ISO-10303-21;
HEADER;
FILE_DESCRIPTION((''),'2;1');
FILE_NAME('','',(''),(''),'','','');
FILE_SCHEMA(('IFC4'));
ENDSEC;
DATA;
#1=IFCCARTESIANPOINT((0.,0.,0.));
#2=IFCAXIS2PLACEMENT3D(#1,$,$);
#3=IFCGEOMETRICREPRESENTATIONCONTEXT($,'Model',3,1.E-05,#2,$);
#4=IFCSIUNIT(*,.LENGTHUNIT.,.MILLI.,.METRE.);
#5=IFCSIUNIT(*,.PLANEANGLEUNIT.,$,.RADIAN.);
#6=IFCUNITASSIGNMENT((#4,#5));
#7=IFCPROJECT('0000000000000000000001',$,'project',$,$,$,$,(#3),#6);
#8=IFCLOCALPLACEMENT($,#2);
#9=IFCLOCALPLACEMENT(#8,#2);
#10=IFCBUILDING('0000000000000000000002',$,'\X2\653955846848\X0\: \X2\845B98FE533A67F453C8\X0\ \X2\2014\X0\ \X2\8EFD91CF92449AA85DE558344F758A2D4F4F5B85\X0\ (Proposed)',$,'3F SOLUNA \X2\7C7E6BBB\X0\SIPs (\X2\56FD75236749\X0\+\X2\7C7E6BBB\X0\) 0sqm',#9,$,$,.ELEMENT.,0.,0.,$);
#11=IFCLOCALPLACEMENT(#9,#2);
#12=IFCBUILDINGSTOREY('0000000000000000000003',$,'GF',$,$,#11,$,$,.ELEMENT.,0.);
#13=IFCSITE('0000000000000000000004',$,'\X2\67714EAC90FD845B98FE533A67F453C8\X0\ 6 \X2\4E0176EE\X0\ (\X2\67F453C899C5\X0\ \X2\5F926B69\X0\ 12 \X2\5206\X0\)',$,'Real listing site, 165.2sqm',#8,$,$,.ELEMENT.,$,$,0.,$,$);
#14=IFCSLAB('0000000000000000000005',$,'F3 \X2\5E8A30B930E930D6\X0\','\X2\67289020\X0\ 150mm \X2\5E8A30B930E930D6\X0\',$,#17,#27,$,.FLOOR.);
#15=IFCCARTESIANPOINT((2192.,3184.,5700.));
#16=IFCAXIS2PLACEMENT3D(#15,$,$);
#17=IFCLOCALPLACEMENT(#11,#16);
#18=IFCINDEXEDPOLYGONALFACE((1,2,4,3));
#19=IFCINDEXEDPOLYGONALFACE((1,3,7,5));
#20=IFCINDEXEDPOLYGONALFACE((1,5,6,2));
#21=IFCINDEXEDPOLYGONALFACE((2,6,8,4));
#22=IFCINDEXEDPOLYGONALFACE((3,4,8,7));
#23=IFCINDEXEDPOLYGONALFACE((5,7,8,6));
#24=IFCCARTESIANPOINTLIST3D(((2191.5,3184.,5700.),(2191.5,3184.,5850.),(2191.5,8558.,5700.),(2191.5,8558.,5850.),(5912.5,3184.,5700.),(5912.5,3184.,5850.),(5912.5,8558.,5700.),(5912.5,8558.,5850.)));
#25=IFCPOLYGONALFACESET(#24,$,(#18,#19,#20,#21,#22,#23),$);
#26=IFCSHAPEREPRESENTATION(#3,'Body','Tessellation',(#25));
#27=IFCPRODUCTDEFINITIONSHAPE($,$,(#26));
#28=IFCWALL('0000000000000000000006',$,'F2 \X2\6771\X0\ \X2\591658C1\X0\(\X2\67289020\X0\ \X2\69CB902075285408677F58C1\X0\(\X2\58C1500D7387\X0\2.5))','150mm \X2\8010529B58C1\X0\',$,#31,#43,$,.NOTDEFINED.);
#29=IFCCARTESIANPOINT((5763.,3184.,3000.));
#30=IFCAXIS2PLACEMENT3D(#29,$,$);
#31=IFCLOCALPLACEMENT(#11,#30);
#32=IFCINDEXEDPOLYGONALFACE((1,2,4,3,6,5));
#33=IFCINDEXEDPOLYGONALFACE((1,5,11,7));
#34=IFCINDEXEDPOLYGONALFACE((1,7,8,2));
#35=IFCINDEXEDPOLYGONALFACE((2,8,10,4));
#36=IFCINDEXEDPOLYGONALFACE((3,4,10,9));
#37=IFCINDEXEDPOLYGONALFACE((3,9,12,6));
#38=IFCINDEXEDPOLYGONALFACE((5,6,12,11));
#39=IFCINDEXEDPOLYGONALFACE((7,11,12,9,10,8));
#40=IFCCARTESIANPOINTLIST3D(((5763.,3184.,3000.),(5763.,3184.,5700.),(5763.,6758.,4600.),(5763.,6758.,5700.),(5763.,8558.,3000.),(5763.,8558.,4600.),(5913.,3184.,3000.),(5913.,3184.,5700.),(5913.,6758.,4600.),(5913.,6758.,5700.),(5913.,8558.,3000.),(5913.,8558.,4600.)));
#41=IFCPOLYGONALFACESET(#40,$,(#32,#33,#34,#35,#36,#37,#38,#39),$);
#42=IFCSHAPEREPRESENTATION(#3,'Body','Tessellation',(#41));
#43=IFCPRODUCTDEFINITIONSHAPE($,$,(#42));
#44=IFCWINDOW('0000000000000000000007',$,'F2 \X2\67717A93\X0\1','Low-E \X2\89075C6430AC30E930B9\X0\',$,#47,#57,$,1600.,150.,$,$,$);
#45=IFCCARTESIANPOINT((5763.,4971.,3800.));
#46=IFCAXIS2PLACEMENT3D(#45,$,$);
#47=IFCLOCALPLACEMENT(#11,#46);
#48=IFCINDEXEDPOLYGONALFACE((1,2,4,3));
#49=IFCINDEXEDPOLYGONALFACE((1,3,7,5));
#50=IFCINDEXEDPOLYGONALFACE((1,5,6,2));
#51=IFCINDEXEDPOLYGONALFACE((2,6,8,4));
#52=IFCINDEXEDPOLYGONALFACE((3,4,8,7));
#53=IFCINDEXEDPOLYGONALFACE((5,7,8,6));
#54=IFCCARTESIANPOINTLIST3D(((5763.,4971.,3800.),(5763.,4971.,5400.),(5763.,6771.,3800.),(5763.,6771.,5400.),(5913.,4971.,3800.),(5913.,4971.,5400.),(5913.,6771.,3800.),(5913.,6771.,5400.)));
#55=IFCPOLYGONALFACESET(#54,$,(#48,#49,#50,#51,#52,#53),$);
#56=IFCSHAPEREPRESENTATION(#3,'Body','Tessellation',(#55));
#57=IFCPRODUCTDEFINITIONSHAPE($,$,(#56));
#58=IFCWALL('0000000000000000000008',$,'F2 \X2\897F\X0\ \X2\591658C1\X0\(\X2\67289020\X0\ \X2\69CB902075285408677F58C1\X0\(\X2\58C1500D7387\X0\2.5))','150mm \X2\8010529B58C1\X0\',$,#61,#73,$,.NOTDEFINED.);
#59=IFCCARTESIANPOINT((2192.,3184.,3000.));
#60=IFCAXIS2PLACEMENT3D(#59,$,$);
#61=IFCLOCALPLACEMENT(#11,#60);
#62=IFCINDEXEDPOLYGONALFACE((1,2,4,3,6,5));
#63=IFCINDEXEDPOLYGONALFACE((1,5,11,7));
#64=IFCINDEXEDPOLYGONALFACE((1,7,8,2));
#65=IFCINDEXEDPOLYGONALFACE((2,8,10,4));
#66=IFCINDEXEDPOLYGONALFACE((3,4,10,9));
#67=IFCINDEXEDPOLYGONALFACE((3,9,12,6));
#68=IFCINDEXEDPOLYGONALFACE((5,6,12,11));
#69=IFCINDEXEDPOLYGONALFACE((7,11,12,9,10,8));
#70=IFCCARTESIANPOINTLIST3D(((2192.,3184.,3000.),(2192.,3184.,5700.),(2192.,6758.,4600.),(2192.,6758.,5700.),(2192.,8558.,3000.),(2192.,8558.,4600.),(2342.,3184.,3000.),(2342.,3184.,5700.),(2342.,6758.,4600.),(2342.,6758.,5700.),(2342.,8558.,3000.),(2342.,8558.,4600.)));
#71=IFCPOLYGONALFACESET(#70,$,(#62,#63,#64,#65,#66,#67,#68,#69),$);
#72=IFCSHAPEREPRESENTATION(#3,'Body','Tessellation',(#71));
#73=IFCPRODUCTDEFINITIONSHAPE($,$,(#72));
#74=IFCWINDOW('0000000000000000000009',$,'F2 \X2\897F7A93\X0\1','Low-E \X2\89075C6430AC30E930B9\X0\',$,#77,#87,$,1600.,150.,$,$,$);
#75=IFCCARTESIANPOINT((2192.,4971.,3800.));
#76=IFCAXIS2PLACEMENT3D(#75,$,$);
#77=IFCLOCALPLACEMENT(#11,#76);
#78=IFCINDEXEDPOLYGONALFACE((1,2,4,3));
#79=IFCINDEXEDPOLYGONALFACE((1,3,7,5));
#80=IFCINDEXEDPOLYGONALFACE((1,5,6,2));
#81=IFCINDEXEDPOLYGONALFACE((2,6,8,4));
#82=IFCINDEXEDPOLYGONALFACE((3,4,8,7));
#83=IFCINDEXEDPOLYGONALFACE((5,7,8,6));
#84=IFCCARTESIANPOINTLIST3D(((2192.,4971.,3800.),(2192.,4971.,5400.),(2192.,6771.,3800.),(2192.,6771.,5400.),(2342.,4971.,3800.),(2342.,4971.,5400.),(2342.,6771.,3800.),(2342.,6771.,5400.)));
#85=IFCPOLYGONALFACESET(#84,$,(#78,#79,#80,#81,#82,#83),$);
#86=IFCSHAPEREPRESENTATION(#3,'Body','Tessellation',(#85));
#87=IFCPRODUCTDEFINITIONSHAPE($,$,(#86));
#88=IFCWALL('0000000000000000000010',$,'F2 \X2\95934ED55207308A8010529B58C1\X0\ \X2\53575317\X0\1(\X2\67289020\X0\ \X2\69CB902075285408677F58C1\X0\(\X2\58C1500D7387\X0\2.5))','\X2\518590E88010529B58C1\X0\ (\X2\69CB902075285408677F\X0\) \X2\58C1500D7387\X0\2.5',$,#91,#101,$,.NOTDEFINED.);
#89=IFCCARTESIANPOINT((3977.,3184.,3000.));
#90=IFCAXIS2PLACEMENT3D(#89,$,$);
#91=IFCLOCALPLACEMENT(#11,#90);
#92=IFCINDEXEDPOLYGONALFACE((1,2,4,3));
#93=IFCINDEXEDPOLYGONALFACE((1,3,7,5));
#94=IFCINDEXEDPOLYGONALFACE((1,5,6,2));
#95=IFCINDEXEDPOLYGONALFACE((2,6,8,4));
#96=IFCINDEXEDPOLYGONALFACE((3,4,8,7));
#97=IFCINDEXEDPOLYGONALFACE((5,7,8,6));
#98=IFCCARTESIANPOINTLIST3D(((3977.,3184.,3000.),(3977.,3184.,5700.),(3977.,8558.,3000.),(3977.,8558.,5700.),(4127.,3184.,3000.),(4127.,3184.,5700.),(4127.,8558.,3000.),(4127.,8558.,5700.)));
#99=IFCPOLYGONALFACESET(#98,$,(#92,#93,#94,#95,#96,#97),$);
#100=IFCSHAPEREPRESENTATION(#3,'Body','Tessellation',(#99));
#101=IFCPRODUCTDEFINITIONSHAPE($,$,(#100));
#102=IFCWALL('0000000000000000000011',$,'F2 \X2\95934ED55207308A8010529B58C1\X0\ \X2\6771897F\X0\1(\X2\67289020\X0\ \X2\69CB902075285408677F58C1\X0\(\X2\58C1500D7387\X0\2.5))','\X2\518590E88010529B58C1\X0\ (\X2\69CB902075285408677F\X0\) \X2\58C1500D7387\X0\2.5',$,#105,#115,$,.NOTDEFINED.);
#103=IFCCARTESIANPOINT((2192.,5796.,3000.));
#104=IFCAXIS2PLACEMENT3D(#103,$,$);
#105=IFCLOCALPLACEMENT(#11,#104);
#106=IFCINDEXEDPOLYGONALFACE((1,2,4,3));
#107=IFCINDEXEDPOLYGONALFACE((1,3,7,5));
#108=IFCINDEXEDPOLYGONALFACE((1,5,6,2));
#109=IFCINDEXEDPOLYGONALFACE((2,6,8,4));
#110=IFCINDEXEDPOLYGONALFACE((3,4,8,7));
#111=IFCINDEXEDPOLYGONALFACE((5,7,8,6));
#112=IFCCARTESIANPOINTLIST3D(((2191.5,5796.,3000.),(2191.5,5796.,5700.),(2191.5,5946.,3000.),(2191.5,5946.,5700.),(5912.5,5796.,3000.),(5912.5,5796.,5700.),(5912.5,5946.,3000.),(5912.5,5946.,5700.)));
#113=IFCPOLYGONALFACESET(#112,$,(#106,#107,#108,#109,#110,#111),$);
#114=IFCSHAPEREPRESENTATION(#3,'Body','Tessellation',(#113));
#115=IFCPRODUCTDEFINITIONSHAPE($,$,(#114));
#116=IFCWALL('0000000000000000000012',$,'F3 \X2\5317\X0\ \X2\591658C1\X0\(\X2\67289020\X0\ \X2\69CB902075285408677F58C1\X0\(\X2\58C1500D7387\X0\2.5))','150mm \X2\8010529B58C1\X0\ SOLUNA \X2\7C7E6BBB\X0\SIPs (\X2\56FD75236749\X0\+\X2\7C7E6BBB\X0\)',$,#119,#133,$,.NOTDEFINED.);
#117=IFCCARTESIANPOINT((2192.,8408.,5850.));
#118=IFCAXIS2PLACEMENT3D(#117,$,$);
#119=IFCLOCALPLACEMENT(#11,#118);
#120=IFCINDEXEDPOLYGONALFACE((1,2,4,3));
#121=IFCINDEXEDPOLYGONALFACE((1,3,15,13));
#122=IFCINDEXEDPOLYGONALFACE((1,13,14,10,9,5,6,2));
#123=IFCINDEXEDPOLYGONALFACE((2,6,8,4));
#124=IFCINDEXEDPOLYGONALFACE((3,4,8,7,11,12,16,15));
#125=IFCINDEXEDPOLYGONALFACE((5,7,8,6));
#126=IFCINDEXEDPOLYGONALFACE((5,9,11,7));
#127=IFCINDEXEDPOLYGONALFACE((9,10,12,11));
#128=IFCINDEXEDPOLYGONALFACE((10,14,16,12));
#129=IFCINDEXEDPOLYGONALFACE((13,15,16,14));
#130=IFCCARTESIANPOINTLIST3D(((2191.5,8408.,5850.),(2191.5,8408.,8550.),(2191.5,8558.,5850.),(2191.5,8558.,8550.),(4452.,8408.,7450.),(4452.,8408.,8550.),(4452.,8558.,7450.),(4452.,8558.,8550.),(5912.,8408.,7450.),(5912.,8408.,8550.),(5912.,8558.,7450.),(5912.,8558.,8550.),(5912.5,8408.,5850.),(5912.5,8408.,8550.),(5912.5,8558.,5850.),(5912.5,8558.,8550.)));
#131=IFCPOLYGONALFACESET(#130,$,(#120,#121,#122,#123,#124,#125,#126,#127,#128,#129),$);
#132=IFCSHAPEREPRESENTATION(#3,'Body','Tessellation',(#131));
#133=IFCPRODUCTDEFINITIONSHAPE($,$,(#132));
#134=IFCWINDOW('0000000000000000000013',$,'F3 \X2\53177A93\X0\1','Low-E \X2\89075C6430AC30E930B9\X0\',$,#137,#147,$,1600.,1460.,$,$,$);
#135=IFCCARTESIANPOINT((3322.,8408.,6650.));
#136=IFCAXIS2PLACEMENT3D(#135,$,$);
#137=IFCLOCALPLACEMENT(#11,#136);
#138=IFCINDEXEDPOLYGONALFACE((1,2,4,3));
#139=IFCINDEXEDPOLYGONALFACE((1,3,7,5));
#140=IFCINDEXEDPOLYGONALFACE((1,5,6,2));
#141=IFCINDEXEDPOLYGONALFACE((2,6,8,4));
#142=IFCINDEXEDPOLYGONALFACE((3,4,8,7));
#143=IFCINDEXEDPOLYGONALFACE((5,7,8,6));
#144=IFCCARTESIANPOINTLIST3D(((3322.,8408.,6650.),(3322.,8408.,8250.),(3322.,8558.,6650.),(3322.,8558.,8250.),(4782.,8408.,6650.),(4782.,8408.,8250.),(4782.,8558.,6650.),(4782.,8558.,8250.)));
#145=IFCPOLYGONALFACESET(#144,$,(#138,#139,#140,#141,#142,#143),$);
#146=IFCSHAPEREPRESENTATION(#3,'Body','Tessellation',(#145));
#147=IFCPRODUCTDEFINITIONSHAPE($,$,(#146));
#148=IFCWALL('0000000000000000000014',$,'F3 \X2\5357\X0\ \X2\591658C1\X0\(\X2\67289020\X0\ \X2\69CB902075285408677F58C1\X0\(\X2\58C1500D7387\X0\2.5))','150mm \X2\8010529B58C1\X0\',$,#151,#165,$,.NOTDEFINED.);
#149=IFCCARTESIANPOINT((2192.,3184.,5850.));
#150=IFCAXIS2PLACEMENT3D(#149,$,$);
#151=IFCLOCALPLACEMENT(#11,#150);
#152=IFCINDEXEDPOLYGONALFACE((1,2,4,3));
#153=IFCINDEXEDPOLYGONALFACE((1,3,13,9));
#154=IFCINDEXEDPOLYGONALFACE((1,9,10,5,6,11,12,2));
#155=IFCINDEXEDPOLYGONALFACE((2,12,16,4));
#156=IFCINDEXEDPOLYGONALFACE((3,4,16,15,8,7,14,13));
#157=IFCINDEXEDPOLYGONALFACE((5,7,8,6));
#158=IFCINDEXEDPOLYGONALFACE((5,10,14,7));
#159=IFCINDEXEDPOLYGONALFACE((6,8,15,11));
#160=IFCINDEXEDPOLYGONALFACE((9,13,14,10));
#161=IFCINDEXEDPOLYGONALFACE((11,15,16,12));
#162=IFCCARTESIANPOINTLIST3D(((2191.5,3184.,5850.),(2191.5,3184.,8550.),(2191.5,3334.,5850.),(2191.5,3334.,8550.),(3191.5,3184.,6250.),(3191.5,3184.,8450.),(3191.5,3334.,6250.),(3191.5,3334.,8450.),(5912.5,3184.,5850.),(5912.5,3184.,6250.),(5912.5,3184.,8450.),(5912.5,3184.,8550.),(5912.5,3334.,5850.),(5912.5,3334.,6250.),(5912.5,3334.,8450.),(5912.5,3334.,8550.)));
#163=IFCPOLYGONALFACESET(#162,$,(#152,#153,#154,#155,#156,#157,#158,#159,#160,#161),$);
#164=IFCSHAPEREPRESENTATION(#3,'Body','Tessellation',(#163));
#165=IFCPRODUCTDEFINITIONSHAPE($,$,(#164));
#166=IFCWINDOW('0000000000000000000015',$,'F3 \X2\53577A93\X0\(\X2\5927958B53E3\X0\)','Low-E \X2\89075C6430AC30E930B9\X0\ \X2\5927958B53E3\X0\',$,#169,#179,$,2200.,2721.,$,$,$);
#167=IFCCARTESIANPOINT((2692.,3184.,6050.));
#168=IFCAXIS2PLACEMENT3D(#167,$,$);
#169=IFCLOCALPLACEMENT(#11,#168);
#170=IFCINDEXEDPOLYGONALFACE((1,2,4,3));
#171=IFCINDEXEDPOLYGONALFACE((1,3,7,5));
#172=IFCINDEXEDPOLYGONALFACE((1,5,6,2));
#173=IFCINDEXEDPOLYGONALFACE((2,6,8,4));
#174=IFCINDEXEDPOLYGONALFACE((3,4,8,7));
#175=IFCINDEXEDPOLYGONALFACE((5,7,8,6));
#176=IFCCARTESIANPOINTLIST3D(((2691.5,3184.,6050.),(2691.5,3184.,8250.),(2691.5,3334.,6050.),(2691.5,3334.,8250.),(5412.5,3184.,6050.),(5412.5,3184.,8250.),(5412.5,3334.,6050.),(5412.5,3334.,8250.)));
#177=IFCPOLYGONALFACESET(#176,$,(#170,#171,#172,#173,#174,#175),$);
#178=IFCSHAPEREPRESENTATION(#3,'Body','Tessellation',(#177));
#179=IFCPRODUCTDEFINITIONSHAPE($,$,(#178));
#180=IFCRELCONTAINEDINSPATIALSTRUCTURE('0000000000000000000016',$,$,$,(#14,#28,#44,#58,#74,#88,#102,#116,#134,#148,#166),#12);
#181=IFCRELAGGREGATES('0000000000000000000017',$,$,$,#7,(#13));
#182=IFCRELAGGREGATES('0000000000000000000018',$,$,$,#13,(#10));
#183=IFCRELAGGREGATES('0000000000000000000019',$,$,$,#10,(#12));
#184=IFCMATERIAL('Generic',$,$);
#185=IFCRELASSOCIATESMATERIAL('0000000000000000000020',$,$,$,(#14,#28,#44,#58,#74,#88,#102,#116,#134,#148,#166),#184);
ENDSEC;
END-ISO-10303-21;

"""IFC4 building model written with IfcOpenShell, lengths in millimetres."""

from ifc_helpers import new_model, si_unit, frame, frame_2d, origin, place, context, project, spatial, rectangle, extrude, material, element, fill, save


model = new_model("IFC4")

# Units and contexts
model_context = context("Model", 3, precision=1e-05, world=origin())
ifc_project = project(units=[si_unit("LENGTHUNIT", "METRE", prefix="MILLI"), si_unit("PLANEANGLEUNIT", "RADIAN")], contexts=[model_context])

# Site, building, storey
site_placement = place(None, origin())
site = spatial("IfcSite", under=ifc_project, at=site_placement, Name="東京都葛飾区柴又 6 丁目 (柴又駅 徒歩 12 分)", ObjectType="Real listing site, 165.2sqm", CompositionType="ELEMENT", RefElevation=0.0)
building_placement = place(site_placement, origin())
building = spatial("IfcBuilding", under=site, at=building_placement, Name="改善案: 葛飾区柴又 — 軽量鉄骨工場併設住宅 (Proposed)", ObjectType="3F SOLUNA 籾殻SIPs (国産杉+籾殻) 0sqm", CompositionType="ELEMENT", ElevationOfRefHeight=0.0, ElevationOfTerrain=0.0)
storey_placement = place(building_placement, origin())
storey = spatial("IfcBuildingStorey", under=building, at=storey_placement, Name="GF", CompositionType="ELEMENT", Elevation=0.0)

# Slab
ifc_material_1 = material(Name="Generic")
slab_placement = place(storey_placement, frame((2192.0, 3184.0, 5700.0)))
element("IfcSlab", 1, at=slab_placement, inside=storey, material=ifc_material_1, Name="F3 床スラブ", Description="木造 150mm 床スラブ", PredefinedType="FLOOR", context=model_context, shape_type="SweptSolid", body=[
    extrude(rectangle(XDim=3721.0, YDim=5374.0, at=frame_2d((1860.0, 2687.0))), frame((2192.0, 3184.0, 5700.0)), (0.0, 0.0, 1.0), 150.0),
])

# Walls, openings, windows
wall_1_placement = place(storey_placement, frame((5763.0, 3184.0, 3000.0)))
wall_1 = element("IfcWall", 2, at=wall_1_placement, inside=storey, material=ifc_material_1, Name="F2 東 外壁(木造 構造用合板壁(壁倍率2.5))", Description="150mm 耐力壁", PredefinedType="NOTDEFINED", context=model_context, shape_type="SweptSolid", body=[
    extrude(rectangle(XDim=150.0, YDim=5374.0, at=frame_2d((75.0, 2687.0))), frame((5763.0, 3184.0, 3000.0)), (0.0, 0.0, 1.0), 2700.0),
])
opening_1_placement = place(storey_placement, frame((5763.0, 4971.0, 3800.0)))
opening_1 = element("IfcOpeningElement", 3, at=opening_1_placement, cuts=wall_1, PredefinedType="NOTDEFINED", context=model_context, shape_type="SweptSolid", body=[
    extrude(rectangle(XDim=150.0, YDim=1800.0, at=frame_2d((75.0, 900.0))), frame((5763.0, 4971.0, 3800.0)), (0.0, 0.0, 1.0), 1600.0),
])
window_1_placement = place(storey_placement, frame((5763.0, 4971.0, 3800.0)))
window_1 = element("IfcWindow", 4, at=window_1_placement, inside=storey, material=ifc_material_1, Name="F2 東窓1", Description="Low-E 複層ガラス", OverallHeight=1600.0, OverallWidth=150.0, context=model_context, shape_type="SweptSolid", body=[
    extrude(rectangle(XDim=150.0, YDim=1800.0, at=frame_2d((75.0, 900.0))), frame((5763.0, 4971.0, 3800.0)), (0.0, 0.0, 1.0), 1600.0),
])
fill(opening_1, window_1)
wall_2_placement = place(storey_placement, frame((2192.0, 3184.0, 3000.0)))
wall_2 = element("IfcWall", 5, at=wall_2_placement, inside=storey, material=ifc_material_1, Name="F2 西 外壁(木造 構造用合板壁(壁倍率2.5))", Description="150mm 耐力壁", PredefinedType="NOTDEFINED", context=model_context, shape_type="SweptSolid", body=[
    extrude(rectangle(XDim=150.0, YDim=5374.0, at=frame_2d((75.0, 2687.0))), frame((2192.0, 3184.0, 3000.0)), (0.0, 0.0, 1.0), 2700.0),
])
opening_2_placement = place(storey_placement, frame((2192.0, 4971.0, 3800.0)))
opening_2 = element("IfcOpeningElement", 6, at=opening_2_placement, cuts=wall_2, PredefinedType="NOTDEFINED", context=model_context, shape_type="SweptSolid", body=[
    extrude(rectangle(XDim=150.0, YDim=1800.0, at=frame_2d((75.0, 900.0))), frame((2192.0, 4971.0, 3800.0)), (0.0, 0.0, 1.0), 1600.0),
])
window_2_placement = place(storey_placement, frame((2192.0, 4971.0, 3800.0)))
window_2 = element("IfcWindow", 7, at=window_2_placement, inside=storey, material=ifc_material_1, Name="F2 西窓1", Description="Low-E 複層ガラス", OverallHeight=1600.0, OverallWidth=150.0, context=model_context, shape_type="SweptSolid", body=[
    extrude(rectangle(XDim=150.0, YDim=1800.0, at=frame_2d((75.0, 900.0))), frame((2192.0, 4971.0, 3800.0)), (0.0, 0.0, 1.0), 1600.0),
])
fill(opening_2, window_2)

# Walls
wall_3_placement = place(storey_placement, frame((3977.0, 3184.0, 3000.0)))
element("IfcWall", 8, at=wall_3_placement, inside=storey, material=ifc_material_1, Name="F2 間仕切り耐力壁 南北1(木造 構造用合板壁(壁倍率2.5))", Description="内部耐力壁 (構造用合板) 壁倍率2.5", PredefinedType="NOTDEFINED", context=model_context, shape_type="SweptSolid", body=[
    extrude(rectangle(XDim=150.0, YDim=5374.0, at=frame_2d((75.0, 2687.0))), frame((3977.0, 3184.0, 3000.0)), (0.0, 0.0, 1.0), 2700.0),
])
wall_4_placement = place(storey_placement, frame((2192.0, 5796.0, 3000.0)))
element("IfcWall", 9, at=wall_4_placement, inside=storey, material=ifc_material_1, Name="F2 間仕切り耐力壁 東西1(木造 構造用合板壁(壁倍率2.5))", Description="内部耐力壁 (構造用合板) 壁倍率2.5", PredefinedType="NOTDEFINED", context=model_context, shape_type="SweptSolid", body=[
    extrude(rectangle(XDim=3721.0, YDim=150.0, at=frame_2d((1860.0, 75.0))), frame((2192.0, 5796.0, 3000.0)), (0.0, 0.0, 1.0), 2700.0),
])

# Walls, openings, windows
wall_5_placement = place(storey_placement, frame((2192.0, 8408.0, 5850.0)))
wall_5 = element("IfcWall", 10, at=wall_5_placement, inside=storey, material=ifc_material_1, Name="F3 北 外壁(木造 構造用合板壁(壁倍率2.5))", Description="150mm 耐力壁 SOLUNA 籾殻SIPs (国産杉+籾殻)", PredefinedType="NOTDEFINED", context=model_context, shape_type="SweptSolid", body=[
    extrude(rectangle(XDim=3721.0, YDim=150.0, at=frame_2d((1860.0, 75.0))), frame((2192.0, 8408.0, 5850.0)), (0.0, 0.0, 1.0), 2700.0),
])
opening_3_placement = place(storey_placement, frame((3322.0, 8408.0, 6650.0)))
opening_3 = element("IfcOpeningElement", 11, at=opening_3_placement, cuts=wall_5, PredefinedType="NOTDEFINED", context=model_context, shape_type="SweptSolid", body=[
    extrude(rectangle(XDim=1460.0, YDim=150.0, at=frame_2d((730.0, 75.0))), frame((3322.0, 8408.0, 6650.0)), (0.0, 0.0, 1.0), 1600.0),
])
window_3_placement = place(storey_placement, frame((3322.0, 8408.0, 6650.0)))
window_3 = element("IfcWindow", 12, at=window_3_placement, inside=storey, material=ifc_material_1, Name="F3 北窓1", Description="Low-E 複層ガラス", OverallHeight=1600.0, OverallWidth=1460.0, context=model_context, shape_type="SweptSolid", body=[
    extrude(rectangle(XDim=1460.0, YDim=150.0, at=frame_2d((730.0, 75.0))), frame((3322.0, 8408.0, 6650.0)), (0.0, 0.0, 1.0), 1600.0),
])
fill(opening_3, window_3)
wall_6_placement = place(storey_placement, frame((2192.0, 3184.0, 5850.0)))
wall_6 = element("IfcWall", 13, at=wall_6_placement, inside=storey, material=ifc_material_1, Name="F3 南 外壁(木造 構造用合板壁(壁倍率2.5))", Description="150mm 耐力壁", PredefinedType="NOTDEFINED", context=model_context, shape_type="SweptSolid", body=[
    extrude(rectangle(XDim=3721.0, YDim=150.0, at=frame_2d((1860.0, 75.0))), frame((2192.0, 3184.0, 5850.0)), (0.0, 0.0, 1.0), 2700.0),
])
opening_4_placement = place(storey_placement, frame((2692.0, 3184.0, 6050.0)))
opening_4 = element("IfcOpeningElement", 14, at=opening_4_placement, cuts=wall_6, PredefinedType="NOTDEFINED", context=model_context, shape_type="SweptSolid", body=[
    extrude(rectangle(XDim=2721.0, YDim=150.0, at=frame_2d((1360.0, 75.0))), frame((2692.0, 3184.0, 6050.0)), (0.0, 0.0, 1.0), 2200.0),
])
window_4_placement = place(storey_placement, frame((2692.0, 3184.0, 6050.0)))
window_4 = element("IfcWindow", 15, at=window_4_placement, inside=storey, material=ifc_material_1, Name="F3 南窓(大開口)", Description="Low-E 複層ガラス 大開口", OverallHeight=2200.0, OverallWidth=2721.0, context=model_context, shape_type="SweptSolid", body=[
    extrude(rectangle(XDim=2721.0, YDim=150.0, at=frame_2d((1360.0, 75.0))), frame((2692.0, 3184.0, 6050.0)), (0.0, 0.0, 1.0), 2200.0),
])
fill(opening_4, window_4)

save(model, "model.ifc")
